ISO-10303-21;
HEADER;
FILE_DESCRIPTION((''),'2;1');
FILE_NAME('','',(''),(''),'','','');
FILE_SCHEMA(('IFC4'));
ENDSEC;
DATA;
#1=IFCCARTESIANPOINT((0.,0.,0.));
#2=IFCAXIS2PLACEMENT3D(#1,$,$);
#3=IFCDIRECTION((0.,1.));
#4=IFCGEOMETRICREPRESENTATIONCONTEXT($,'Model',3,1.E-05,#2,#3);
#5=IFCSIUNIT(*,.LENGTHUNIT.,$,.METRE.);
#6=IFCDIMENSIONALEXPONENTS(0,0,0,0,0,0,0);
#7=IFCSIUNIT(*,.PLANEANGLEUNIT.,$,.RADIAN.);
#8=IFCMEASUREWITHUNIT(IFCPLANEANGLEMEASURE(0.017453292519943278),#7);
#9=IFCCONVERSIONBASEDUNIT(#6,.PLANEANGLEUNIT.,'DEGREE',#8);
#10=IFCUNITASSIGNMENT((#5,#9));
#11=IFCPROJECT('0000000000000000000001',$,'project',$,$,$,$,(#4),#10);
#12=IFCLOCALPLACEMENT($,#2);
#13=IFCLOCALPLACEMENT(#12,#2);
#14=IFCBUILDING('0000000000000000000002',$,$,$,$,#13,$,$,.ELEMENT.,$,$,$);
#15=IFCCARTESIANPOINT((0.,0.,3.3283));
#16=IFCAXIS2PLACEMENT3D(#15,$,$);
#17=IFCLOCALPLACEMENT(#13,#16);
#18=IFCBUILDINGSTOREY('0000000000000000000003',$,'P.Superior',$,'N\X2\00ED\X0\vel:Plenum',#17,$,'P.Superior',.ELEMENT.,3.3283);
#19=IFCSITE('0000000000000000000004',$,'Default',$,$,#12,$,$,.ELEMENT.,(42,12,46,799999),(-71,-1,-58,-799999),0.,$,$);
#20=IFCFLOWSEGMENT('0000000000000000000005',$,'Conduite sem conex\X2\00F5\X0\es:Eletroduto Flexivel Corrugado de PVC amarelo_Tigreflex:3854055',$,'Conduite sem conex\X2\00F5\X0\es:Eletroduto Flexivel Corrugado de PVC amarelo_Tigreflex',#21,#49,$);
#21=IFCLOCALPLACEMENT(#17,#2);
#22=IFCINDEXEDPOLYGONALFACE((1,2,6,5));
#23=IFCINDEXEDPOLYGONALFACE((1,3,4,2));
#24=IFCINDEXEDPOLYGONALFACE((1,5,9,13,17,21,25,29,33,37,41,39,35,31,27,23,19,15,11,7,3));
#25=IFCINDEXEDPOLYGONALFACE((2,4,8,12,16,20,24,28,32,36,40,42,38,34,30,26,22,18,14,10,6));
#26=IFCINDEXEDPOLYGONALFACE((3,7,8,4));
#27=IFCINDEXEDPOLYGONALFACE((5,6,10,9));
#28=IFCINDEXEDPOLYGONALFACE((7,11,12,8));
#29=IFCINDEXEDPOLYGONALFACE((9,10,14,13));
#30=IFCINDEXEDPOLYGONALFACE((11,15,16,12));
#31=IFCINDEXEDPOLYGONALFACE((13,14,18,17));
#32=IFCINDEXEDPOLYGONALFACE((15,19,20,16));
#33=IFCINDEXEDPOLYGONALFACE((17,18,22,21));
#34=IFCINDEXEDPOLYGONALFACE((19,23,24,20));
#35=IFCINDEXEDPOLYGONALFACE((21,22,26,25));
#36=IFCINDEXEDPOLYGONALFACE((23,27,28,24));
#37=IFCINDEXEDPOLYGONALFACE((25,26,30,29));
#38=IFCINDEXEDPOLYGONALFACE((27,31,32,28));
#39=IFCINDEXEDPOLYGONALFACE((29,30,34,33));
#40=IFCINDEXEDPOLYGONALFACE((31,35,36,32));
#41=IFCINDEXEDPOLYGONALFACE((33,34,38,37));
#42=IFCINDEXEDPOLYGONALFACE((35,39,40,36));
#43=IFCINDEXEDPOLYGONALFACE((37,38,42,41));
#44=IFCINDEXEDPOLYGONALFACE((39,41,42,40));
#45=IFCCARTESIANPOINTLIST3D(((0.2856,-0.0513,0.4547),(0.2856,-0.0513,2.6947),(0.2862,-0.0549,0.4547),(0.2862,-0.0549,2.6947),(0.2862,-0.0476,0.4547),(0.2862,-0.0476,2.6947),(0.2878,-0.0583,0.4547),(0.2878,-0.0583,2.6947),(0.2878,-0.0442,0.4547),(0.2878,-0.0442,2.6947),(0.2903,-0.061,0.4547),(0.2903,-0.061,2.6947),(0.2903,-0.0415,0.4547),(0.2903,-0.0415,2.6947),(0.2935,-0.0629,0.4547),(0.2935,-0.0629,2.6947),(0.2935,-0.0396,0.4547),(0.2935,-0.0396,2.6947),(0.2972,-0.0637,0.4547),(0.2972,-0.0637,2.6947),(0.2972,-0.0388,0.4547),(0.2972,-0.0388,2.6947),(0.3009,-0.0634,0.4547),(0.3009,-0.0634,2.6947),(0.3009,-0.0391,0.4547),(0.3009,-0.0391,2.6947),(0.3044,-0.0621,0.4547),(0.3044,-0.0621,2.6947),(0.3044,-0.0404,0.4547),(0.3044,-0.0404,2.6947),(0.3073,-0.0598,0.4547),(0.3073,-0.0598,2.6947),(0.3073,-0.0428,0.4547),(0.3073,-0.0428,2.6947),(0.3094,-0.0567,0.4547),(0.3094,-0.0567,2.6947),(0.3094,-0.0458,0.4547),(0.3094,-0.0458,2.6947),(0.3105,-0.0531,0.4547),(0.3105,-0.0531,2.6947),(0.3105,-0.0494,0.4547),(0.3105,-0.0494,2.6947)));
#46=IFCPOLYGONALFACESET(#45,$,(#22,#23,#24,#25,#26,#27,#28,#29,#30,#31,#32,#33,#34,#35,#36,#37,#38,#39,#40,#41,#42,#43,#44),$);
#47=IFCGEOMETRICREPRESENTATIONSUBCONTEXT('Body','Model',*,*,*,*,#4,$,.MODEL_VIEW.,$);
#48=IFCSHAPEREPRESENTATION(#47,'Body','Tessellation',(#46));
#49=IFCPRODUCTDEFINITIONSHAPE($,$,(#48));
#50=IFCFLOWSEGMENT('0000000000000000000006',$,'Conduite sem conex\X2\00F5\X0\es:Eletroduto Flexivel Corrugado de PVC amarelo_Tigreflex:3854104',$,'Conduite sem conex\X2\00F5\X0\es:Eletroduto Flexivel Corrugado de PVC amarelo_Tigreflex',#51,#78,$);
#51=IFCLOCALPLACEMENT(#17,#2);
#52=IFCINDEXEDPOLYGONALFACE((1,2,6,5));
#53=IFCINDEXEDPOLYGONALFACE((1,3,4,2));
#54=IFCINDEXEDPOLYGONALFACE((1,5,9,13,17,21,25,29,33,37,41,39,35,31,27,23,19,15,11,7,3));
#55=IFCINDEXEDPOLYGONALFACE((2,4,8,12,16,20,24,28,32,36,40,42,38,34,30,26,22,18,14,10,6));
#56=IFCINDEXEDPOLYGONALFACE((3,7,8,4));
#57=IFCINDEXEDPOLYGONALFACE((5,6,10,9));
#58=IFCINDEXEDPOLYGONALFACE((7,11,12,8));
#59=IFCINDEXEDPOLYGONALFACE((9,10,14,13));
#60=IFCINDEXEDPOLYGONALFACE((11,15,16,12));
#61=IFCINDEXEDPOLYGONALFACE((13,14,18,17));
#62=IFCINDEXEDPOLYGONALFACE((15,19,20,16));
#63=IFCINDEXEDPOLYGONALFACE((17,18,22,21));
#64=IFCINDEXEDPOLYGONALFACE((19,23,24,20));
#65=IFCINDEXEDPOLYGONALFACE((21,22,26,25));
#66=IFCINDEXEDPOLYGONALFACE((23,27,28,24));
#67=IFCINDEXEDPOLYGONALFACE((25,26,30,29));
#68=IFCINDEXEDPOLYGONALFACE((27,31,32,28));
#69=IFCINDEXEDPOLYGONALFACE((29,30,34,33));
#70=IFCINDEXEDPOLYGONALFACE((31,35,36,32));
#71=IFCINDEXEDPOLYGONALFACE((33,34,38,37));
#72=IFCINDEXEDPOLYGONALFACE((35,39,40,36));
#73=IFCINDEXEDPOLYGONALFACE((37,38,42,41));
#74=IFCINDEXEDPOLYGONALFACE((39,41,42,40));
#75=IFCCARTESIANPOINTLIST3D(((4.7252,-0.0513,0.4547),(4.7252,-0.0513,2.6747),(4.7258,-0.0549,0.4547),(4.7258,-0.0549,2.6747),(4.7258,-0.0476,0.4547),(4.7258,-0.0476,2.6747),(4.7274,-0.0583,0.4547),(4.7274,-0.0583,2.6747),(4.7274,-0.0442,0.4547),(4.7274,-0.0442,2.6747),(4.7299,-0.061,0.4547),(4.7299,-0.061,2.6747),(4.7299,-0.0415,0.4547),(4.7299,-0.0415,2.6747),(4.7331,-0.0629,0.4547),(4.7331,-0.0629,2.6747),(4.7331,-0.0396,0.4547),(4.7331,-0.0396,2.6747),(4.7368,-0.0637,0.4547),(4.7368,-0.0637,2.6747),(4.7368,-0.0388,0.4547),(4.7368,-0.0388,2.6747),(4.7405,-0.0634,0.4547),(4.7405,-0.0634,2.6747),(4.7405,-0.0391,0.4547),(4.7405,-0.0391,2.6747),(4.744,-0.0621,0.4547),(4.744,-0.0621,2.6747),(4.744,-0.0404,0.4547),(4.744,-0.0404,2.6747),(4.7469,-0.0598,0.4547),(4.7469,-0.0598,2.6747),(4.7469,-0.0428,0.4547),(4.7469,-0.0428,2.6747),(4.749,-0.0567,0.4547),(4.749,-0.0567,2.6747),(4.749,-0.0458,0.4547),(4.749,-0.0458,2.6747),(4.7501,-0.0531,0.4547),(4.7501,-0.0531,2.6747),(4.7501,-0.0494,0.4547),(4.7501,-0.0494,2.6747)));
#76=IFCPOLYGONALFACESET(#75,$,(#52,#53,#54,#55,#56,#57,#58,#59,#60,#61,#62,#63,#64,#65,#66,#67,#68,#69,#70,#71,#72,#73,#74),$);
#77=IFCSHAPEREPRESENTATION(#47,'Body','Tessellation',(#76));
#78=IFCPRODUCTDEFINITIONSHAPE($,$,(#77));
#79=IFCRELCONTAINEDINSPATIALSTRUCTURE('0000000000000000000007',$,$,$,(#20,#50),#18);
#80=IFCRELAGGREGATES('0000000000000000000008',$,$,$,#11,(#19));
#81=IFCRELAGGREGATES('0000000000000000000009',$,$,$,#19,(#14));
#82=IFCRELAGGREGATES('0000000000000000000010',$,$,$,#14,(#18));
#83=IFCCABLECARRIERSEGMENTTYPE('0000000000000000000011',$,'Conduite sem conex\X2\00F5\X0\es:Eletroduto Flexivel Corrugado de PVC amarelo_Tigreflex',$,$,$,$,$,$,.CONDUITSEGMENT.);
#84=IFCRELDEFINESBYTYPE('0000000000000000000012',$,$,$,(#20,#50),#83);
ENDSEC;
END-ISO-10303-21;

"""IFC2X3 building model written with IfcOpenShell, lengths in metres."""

from ifc_helpers import new_model, entity, si_unit, converted_unit, direction, frame, frame_2d, origin, place, context, subcontext, project, spatial, circle, extrude, type_object, element, save


model = new_model("IFC2X3")

# Units and contexts
model_context = context("Model", 3, precision=1e-05, world=origin(), true_north=direction((0.0, 1.0)))
body_context = subcontext(model_context, "Body", "Model", "MODEL_VIEW")
ifc_project = project(units=[si_unit("LENGTHUNIT", "METRE"), converted_unit("PLANEANGLEUNIT", "DEGREE", entity("IfcPlaneAngleMeasure", 0.017453292519943278), si_unit("PLANEANGLEUNIT", "RADIAN"), dimensions=[0, 0, 0, 0, 0, 0, 0])], contexts=[model_context])

# Site, building, storey
site_placement = place(None, origin())
site = spatial("IfcSite", under=ifc_project, at=site_placement, Name="Default", CompositionType="ELEMENT", RefLatitude=(42, 12, 46, 799999), RefLongitude=(-71, -1, -58, -799999), RefElevation=0.0)
building_placement = place(site_placement, origin())
building = spatial("IfcBuilding", under=site, at=building_placement, CompositionType="ELEMENT")
storey_placement = place(building_placement, frame((0.0, 0.0, 3.3283)))
storey = spatial("IfcBuildingStorey", under=building, at=storey_placement, Name="P.Superior", ObjectType="Nível:Plenum", LongName="P.Superior", CompositionType="ELEMENT", Elevation=3.3283)

# Flow segments
cable_carrier_segment_type = type_object("IfcCableCarrierSegmentType", Name="Conduite sem conexões:Eletroduto Flexivel Corrugado de PVC amarelo_Tigreflex", PredefinedType="CONDUITSEGMENT")
flow_segment_1_placement = place(storey_placement, origin())
element("IfcFlowSegment", 1, at=flow_segment_1_placement, inside=storey, type_object=cable_carrier_segment_type, Name="Conduite sem conexões:Eletroduto Flexivel Corrugado de PVC amarelo_Tigreflex:3854055", ObjectType="Conduite sem conexões:Eletroduto Flexivel Corrugado de PVC amarelo_Tigreflex", context=body_context, shape_type="SweptSolid", body=[
    extrude(circle(Radius=0.0125, at=frame_2d((0.0, 0.0), x_axis=(1.0, 0.0))), frame((0.2981, -0.0513, 0.4547), z_axis=(0.0, 0.0, 1.0), x_axis=(-1.0, 0.0, 0.0)), (0.0, 0.0, 1.0), 2.24),
])
flow_segment_2_placement = place(storey_placement, origin())
element("IfcFlowSegment", 2, at=flow_segment_2_placement, inside=storey, type_object=cable_carrier_segment_type, Name="Conduite sem conexões:Eletroduto Flexivel Corrugado de PVC amarelo_Tigreflex:3854104", ObjectType="Conduite sem conexões:Eletroduto Flexivel Corrugado de PVC amarelo_Tigreflex", context=body_context, shape_type="SweptSolid", body=[
    extrude(circle(Radius=0.0125, at=frame_2d((0.0, 0.0), x_axis=(1.0, 0.0))), frame((4.7377, -0.0513, 0.4547), z_axis=(0.0, 0.0, 1.0), x_axis=(-1.0, 0.0, 0.0)), (0.0, 0.0, 1.0), 2.22),
])

save(model, "model.ifc")
